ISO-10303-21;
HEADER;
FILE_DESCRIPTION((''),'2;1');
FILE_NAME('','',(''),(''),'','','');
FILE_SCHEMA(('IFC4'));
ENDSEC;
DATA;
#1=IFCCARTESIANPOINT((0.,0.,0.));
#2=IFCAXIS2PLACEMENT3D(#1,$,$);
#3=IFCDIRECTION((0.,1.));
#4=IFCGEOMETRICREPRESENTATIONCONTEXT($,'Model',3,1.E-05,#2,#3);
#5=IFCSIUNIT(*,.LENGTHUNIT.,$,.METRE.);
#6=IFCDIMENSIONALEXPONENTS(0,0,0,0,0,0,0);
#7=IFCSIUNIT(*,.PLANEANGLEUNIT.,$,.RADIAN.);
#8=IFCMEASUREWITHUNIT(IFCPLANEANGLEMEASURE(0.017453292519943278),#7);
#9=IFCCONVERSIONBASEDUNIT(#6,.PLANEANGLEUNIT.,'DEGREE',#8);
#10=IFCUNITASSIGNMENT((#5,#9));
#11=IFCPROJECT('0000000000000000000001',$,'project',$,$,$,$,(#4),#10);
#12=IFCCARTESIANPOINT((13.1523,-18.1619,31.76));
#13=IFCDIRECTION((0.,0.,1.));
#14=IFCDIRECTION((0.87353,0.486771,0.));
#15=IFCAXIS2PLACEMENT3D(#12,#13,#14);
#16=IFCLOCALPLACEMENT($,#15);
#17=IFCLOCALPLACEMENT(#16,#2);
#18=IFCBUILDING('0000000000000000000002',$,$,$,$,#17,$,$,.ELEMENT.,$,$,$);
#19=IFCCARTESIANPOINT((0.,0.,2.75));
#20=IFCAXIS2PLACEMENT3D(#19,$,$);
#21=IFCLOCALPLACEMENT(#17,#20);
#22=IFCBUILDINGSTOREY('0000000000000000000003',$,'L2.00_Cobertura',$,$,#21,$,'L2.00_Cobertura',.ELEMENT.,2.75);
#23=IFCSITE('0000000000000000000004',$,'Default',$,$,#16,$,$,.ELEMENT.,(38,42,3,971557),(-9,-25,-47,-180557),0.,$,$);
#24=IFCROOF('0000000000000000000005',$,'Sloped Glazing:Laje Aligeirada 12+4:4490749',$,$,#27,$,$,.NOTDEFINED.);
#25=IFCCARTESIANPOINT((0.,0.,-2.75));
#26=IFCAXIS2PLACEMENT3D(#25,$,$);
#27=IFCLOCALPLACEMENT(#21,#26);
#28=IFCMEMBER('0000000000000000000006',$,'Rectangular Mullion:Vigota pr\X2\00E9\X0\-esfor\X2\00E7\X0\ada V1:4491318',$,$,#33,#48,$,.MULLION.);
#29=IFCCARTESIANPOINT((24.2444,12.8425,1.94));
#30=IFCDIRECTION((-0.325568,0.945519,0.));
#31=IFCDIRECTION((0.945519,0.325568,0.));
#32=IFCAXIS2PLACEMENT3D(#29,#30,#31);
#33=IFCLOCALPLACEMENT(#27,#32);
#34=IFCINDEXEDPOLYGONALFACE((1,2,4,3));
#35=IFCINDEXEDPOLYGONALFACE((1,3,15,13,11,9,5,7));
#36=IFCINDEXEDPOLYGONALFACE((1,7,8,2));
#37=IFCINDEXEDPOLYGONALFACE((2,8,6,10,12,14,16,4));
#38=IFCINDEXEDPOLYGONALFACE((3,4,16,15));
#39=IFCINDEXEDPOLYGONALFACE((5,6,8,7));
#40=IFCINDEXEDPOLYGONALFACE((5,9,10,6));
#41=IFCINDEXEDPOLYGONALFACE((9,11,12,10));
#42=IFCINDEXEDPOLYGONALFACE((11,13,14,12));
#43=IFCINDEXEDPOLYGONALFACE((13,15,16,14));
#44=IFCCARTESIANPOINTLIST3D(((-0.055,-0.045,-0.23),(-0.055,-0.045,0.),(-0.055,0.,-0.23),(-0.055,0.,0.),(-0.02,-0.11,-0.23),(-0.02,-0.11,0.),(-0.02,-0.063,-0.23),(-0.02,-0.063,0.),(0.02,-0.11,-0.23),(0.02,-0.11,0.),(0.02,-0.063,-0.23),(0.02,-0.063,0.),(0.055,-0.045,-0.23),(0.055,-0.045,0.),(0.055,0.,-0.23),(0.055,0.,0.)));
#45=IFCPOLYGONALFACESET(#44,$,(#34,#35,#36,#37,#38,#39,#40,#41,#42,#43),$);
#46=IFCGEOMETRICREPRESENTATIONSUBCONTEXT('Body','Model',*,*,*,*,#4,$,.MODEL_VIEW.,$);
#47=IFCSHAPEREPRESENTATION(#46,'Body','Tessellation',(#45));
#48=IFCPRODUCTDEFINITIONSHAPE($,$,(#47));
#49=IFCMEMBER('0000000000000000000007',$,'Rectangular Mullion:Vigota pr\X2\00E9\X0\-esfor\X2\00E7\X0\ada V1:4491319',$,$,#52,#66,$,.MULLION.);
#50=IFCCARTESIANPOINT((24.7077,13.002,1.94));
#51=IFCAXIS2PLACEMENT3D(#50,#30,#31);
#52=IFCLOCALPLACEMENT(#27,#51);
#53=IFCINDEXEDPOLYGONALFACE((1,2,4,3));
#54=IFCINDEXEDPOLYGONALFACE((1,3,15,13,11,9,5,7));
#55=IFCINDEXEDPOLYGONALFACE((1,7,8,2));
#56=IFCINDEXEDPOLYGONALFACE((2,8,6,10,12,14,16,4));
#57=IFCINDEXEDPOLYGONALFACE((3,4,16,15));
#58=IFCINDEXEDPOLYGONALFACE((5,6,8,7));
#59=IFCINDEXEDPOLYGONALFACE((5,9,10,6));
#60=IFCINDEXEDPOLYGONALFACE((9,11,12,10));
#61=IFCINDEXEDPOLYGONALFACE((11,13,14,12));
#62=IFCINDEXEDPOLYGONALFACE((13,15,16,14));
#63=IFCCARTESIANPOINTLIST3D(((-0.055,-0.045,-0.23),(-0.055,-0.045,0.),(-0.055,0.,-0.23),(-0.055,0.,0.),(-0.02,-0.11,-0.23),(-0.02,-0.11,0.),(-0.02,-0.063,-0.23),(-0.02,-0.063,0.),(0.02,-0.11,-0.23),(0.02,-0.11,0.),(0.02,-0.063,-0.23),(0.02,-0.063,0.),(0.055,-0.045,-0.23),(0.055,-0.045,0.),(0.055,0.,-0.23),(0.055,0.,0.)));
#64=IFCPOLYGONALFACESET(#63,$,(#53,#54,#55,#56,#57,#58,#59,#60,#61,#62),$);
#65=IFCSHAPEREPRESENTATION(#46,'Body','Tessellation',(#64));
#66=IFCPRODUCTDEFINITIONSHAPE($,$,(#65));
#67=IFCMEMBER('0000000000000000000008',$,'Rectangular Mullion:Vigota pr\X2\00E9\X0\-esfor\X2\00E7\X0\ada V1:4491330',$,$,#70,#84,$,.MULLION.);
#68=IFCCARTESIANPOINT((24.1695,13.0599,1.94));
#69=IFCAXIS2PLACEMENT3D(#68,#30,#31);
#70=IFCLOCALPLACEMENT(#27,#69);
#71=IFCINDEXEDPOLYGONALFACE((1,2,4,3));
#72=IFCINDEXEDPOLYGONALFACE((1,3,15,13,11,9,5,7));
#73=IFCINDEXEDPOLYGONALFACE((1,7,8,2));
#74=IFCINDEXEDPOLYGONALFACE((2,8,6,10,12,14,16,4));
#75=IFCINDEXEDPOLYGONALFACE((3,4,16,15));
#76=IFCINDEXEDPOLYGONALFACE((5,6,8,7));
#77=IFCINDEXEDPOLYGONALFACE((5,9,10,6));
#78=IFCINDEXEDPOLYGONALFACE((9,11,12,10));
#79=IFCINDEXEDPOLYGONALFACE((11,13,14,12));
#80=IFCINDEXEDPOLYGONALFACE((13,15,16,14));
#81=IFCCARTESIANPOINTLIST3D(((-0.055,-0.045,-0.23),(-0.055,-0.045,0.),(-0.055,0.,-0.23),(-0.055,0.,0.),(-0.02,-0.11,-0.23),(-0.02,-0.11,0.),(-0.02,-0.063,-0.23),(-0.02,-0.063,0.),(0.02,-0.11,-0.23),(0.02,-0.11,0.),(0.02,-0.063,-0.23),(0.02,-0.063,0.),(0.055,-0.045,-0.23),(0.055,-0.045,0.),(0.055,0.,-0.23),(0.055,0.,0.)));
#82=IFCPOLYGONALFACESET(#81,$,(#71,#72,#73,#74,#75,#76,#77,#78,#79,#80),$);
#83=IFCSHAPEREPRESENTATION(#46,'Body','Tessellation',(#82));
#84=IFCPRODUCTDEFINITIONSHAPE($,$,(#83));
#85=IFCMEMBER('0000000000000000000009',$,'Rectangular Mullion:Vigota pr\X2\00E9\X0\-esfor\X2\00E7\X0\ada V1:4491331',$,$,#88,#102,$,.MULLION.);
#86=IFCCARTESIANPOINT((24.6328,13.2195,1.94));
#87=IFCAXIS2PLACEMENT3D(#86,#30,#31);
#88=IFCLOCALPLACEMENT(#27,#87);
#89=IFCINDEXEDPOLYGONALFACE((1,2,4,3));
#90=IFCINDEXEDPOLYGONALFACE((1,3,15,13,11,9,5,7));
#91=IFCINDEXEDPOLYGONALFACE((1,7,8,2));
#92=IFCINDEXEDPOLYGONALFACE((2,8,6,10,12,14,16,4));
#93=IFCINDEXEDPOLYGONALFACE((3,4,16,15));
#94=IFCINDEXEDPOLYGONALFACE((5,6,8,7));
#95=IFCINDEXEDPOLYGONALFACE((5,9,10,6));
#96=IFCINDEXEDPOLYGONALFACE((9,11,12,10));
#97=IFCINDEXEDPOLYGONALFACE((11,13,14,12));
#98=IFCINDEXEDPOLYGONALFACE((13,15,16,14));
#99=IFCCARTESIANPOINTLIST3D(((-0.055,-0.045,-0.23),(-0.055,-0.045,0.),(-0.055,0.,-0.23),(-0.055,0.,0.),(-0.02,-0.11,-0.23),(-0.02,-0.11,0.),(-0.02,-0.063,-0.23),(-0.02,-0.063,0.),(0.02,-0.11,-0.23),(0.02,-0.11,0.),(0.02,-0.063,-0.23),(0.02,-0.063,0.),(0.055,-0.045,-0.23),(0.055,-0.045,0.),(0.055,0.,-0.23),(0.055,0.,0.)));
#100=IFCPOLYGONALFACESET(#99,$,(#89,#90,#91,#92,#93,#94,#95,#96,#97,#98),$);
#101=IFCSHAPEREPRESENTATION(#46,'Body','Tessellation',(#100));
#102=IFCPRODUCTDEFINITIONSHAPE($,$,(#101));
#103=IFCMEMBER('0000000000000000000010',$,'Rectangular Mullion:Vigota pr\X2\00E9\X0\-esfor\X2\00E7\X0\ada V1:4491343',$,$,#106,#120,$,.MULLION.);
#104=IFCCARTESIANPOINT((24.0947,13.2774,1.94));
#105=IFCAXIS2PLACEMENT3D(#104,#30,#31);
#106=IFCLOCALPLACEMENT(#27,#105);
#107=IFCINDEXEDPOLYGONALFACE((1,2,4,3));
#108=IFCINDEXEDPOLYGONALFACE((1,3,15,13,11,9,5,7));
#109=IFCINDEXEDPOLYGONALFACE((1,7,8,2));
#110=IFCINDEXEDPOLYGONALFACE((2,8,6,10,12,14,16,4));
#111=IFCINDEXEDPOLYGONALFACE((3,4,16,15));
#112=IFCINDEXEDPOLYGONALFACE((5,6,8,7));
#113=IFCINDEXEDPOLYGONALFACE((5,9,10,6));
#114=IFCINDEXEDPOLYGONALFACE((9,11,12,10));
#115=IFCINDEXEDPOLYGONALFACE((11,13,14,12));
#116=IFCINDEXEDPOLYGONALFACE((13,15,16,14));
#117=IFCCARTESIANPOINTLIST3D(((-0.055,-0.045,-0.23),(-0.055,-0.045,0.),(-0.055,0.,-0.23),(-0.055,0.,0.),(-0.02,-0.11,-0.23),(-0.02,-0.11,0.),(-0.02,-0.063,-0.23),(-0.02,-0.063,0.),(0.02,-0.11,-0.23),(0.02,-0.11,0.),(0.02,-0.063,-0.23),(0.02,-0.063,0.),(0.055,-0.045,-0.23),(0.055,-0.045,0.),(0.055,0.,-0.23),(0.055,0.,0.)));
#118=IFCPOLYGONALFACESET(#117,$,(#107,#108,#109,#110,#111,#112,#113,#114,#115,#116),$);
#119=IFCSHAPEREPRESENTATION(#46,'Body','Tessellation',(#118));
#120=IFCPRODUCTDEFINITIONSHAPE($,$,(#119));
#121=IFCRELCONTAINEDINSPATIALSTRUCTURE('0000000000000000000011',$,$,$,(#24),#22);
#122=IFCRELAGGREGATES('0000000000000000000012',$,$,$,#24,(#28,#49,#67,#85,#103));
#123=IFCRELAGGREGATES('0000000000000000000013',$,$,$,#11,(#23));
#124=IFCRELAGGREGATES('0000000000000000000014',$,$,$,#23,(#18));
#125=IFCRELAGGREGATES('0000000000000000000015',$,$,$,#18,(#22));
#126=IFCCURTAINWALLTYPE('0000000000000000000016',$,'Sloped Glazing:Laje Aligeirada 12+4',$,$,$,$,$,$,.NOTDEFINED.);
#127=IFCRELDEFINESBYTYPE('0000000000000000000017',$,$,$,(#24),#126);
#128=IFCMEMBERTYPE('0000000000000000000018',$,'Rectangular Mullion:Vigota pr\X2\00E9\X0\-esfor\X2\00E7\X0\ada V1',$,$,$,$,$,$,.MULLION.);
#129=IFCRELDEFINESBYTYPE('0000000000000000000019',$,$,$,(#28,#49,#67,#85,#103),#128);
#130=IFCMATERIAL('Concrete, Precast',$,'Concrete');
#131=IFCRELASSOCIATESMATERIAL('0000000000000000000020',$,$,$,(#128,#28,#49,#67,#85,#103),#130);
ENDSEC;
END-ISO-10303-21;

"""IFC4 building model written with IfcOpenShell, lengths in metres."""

from ifc_helpers import new_model, entity, si_unit, converted_unit, direction, frame, origin, place, context, subcontext, project, spatial, indexed_curve, outline, extrude, source, transform, mapped, material, type_object, type_shapes, element, aggregate, save


model = new_model("IFC4")

# Units and contexts
model_context = context("Model", 3, precision=1e-05, world=origin(), true_north=direction((0.0, 1.0)))
body_context = subcontext(model_context, "Body", "Model", "MODEL_VIEW")
ifc_project = project(units=[si_unit("LENGTHUNIT", "METRE"), converted_unit("PLANEANGLEUNIT", "DEGREE", entity("IfcPlaneAngleMeasure", 0.017453292519943278), si_unit("PLANEANGLEUNIT", "RADIAN"), dimensions=[0, 0, 0, 0, 0, 0, 0])], contexts=[model_context])

# Site, building, storey
site_placement = place(None, frame((13.1523, -18.1619, 31.76), z_axis=(0.0, 0.0, 1.0), x_axis=(0.87353, 0.486771, 0.0)))
site = spatial("IfcSite", under=ifc_project, at=site_placement, Name="Default", CompositionType="ELEMENT", RefLatitude=(38, 42, 3, 971557), RefLongitude=(-9, -25, -47, -180557), RefElevation=0.0)
building_placement = place(site_placement, origin())
building = spatial("IfcBuilding", under=site, at=building_placement, CompositionType="ELEMENT")
storey_placement = place(building_placement, frame((0.0, 0.0, 2.75)))
storey = spatial("IfcBuildingStorey", under=building, at=storey_placement, Name="L2.00_Cobertura", LongName="L2.00_Cobertura", CompositionType="ELEMENT", Elevation=2.75)

# Roof, members
curtain_wall_type = type_object("IfcCurtainWallType", Name="Sloped Glazing:Laje Aligeirada 12+4", PredefinedType="NOTDEFINED")
roof_placement = place(storey_placement, frame((0.0, 0.0, -2.75)))
roof = element("IfcRoof", 1, at=roof_placement, inside=storey, type_object=curtain_wall_type, Name="Sloped Glazing:Laje Aligeirada 12+4:4490749", PredefinedType="NOTDEFINED")
ifc_material_1 = material(Name="Concrete, Precast", Category="Concrete")
member_type = type_object("IfcMemberType", Name="Rectangular Mullion:Vigota pré-esforçada V1", PredefinedType="MULLION", material=ifc_material_1)
shared_shape_1 = source(origin(), body_context, "Body", "SweptSolid", [
    extrude(outline(indexed_curve([(-0.055, -0.0545), (0.055, -0.0545), (0.055, -0.0095), (0.02, 0.0085), (0.02, 0.0555), (-0.02, 0.0555), (-0.02, 0.0085), (-0.055, -0.0095), (-0.055, -0.0545)], self_intersect=False)), frame((0.0, -0.0545, -0.23), z_axis=(0.0, 0.0, 1.0), x_axis=(-1.0, 0.0, 0.0)), (0.0, 0.0, 1.0), 0.23),
])
type_shapes(member_type, [shared_shape_1])
member_1_placement = place(roof_placement, frame((24.2444, 12.8425, 1.94), z_axis=(-0.325568, 0.945519, 0.0), x_axis=(0.945519, 0.325568, 0.0)))
member_1 = element("IfcMember", 2, at=member_1_placement, type_object=member_type, material=ifc_material_1, Name="Rectangular Mullion:Vigota pré-esforçada V1:4491318", PredefinedType="MULLION", context=body_context, shape_type="MappedRepresentation", body=[
    mapped(shared_shape_1, transform((0.0, 0.0, 0.0), scale=1.0)),
])
member_2_placement = place(roof_placement, frame((24.7077, 13.002, 1.94), z_axis=(-0.325568, 0.945519, 0.0), x_axis=(0.945519, 0.325568, 0.0)))
member_2 = element("IfcMember", 3, at=member_2_placement, type_object=member_type, material=ifc_material_1, Name="Rectangular Mullion:Vigota pré-esforçada V1:4491319", PredefinedType="MULLION", context=body_context, shape_type="MappedRepresentation", body=[
    mapped(shared_shape_1, transform((0.0, 0.0, 0.0), scale=1.0)),
])
member_3_placement = place(roof_placement, frame((24.1695, 13.0599, 1.94), z_axis=(-0.325568, 0.945519, 0.0), x_axis=(0.945519, 0.325568, 0.0)))
member_3 = element("IfcMember", 4, at=member_3_placement, type_object=member_type, material=ifc_material_1, Name="Rectangular Mullion:Vigota pré-esforçada V1:4491330", PredefinedType="MULLION", context=body_context, shape_type="MappedRepresentation", body=[
    mapped(shared_shape_1, transform((0.0, 0.0, 0.0), scale=1.0)),
])
member_4_placement = place(roof_placement, frame((24.6328, 13.2195, 1.94), z_axis=(-0.325568, 0.945519, 0.0), x_axis=(0.945519, 0.325568, 0.0)))
member_4 = element("IfcMember", 5, at=member_4_placement, type_object=member_type, material=ifc_material_1, Name="Rectangular Mullion:Vigota pré-esforçada V1:4491331", PredefinedType="MULLION", context=body_context, shape_type="MappedRepresentation", body=[
    mapped(shared_shape_1, transform((0.0, 0.0, 0.0), scale=1.0)),
])
member_5_placement = place(roof_placement, frame((24.0947, 13.2774, 1.94), z_axis=(-0.325568, 0.945519, 0.0), x_axis=(0.945519, 0.325568, 0.0)))
member_5 = element("IfcMember", 6, at=member_5_placement, type_object=member_type, material=ifc_material_1, Name="Rectangular Mullion:Vigota pré-esforçada V1:4491343", PredefinedType="MULLION", context=body_context, shape_type="MappedRepresentation", body=[
    mapped(shared_shape_1, transform((0.0, 0.0, 0.0), scale=1.0)),
])
aggregate(roof, [member_1, member_2, member_3, member_4, member_5])

save(model, "model.ifc")
